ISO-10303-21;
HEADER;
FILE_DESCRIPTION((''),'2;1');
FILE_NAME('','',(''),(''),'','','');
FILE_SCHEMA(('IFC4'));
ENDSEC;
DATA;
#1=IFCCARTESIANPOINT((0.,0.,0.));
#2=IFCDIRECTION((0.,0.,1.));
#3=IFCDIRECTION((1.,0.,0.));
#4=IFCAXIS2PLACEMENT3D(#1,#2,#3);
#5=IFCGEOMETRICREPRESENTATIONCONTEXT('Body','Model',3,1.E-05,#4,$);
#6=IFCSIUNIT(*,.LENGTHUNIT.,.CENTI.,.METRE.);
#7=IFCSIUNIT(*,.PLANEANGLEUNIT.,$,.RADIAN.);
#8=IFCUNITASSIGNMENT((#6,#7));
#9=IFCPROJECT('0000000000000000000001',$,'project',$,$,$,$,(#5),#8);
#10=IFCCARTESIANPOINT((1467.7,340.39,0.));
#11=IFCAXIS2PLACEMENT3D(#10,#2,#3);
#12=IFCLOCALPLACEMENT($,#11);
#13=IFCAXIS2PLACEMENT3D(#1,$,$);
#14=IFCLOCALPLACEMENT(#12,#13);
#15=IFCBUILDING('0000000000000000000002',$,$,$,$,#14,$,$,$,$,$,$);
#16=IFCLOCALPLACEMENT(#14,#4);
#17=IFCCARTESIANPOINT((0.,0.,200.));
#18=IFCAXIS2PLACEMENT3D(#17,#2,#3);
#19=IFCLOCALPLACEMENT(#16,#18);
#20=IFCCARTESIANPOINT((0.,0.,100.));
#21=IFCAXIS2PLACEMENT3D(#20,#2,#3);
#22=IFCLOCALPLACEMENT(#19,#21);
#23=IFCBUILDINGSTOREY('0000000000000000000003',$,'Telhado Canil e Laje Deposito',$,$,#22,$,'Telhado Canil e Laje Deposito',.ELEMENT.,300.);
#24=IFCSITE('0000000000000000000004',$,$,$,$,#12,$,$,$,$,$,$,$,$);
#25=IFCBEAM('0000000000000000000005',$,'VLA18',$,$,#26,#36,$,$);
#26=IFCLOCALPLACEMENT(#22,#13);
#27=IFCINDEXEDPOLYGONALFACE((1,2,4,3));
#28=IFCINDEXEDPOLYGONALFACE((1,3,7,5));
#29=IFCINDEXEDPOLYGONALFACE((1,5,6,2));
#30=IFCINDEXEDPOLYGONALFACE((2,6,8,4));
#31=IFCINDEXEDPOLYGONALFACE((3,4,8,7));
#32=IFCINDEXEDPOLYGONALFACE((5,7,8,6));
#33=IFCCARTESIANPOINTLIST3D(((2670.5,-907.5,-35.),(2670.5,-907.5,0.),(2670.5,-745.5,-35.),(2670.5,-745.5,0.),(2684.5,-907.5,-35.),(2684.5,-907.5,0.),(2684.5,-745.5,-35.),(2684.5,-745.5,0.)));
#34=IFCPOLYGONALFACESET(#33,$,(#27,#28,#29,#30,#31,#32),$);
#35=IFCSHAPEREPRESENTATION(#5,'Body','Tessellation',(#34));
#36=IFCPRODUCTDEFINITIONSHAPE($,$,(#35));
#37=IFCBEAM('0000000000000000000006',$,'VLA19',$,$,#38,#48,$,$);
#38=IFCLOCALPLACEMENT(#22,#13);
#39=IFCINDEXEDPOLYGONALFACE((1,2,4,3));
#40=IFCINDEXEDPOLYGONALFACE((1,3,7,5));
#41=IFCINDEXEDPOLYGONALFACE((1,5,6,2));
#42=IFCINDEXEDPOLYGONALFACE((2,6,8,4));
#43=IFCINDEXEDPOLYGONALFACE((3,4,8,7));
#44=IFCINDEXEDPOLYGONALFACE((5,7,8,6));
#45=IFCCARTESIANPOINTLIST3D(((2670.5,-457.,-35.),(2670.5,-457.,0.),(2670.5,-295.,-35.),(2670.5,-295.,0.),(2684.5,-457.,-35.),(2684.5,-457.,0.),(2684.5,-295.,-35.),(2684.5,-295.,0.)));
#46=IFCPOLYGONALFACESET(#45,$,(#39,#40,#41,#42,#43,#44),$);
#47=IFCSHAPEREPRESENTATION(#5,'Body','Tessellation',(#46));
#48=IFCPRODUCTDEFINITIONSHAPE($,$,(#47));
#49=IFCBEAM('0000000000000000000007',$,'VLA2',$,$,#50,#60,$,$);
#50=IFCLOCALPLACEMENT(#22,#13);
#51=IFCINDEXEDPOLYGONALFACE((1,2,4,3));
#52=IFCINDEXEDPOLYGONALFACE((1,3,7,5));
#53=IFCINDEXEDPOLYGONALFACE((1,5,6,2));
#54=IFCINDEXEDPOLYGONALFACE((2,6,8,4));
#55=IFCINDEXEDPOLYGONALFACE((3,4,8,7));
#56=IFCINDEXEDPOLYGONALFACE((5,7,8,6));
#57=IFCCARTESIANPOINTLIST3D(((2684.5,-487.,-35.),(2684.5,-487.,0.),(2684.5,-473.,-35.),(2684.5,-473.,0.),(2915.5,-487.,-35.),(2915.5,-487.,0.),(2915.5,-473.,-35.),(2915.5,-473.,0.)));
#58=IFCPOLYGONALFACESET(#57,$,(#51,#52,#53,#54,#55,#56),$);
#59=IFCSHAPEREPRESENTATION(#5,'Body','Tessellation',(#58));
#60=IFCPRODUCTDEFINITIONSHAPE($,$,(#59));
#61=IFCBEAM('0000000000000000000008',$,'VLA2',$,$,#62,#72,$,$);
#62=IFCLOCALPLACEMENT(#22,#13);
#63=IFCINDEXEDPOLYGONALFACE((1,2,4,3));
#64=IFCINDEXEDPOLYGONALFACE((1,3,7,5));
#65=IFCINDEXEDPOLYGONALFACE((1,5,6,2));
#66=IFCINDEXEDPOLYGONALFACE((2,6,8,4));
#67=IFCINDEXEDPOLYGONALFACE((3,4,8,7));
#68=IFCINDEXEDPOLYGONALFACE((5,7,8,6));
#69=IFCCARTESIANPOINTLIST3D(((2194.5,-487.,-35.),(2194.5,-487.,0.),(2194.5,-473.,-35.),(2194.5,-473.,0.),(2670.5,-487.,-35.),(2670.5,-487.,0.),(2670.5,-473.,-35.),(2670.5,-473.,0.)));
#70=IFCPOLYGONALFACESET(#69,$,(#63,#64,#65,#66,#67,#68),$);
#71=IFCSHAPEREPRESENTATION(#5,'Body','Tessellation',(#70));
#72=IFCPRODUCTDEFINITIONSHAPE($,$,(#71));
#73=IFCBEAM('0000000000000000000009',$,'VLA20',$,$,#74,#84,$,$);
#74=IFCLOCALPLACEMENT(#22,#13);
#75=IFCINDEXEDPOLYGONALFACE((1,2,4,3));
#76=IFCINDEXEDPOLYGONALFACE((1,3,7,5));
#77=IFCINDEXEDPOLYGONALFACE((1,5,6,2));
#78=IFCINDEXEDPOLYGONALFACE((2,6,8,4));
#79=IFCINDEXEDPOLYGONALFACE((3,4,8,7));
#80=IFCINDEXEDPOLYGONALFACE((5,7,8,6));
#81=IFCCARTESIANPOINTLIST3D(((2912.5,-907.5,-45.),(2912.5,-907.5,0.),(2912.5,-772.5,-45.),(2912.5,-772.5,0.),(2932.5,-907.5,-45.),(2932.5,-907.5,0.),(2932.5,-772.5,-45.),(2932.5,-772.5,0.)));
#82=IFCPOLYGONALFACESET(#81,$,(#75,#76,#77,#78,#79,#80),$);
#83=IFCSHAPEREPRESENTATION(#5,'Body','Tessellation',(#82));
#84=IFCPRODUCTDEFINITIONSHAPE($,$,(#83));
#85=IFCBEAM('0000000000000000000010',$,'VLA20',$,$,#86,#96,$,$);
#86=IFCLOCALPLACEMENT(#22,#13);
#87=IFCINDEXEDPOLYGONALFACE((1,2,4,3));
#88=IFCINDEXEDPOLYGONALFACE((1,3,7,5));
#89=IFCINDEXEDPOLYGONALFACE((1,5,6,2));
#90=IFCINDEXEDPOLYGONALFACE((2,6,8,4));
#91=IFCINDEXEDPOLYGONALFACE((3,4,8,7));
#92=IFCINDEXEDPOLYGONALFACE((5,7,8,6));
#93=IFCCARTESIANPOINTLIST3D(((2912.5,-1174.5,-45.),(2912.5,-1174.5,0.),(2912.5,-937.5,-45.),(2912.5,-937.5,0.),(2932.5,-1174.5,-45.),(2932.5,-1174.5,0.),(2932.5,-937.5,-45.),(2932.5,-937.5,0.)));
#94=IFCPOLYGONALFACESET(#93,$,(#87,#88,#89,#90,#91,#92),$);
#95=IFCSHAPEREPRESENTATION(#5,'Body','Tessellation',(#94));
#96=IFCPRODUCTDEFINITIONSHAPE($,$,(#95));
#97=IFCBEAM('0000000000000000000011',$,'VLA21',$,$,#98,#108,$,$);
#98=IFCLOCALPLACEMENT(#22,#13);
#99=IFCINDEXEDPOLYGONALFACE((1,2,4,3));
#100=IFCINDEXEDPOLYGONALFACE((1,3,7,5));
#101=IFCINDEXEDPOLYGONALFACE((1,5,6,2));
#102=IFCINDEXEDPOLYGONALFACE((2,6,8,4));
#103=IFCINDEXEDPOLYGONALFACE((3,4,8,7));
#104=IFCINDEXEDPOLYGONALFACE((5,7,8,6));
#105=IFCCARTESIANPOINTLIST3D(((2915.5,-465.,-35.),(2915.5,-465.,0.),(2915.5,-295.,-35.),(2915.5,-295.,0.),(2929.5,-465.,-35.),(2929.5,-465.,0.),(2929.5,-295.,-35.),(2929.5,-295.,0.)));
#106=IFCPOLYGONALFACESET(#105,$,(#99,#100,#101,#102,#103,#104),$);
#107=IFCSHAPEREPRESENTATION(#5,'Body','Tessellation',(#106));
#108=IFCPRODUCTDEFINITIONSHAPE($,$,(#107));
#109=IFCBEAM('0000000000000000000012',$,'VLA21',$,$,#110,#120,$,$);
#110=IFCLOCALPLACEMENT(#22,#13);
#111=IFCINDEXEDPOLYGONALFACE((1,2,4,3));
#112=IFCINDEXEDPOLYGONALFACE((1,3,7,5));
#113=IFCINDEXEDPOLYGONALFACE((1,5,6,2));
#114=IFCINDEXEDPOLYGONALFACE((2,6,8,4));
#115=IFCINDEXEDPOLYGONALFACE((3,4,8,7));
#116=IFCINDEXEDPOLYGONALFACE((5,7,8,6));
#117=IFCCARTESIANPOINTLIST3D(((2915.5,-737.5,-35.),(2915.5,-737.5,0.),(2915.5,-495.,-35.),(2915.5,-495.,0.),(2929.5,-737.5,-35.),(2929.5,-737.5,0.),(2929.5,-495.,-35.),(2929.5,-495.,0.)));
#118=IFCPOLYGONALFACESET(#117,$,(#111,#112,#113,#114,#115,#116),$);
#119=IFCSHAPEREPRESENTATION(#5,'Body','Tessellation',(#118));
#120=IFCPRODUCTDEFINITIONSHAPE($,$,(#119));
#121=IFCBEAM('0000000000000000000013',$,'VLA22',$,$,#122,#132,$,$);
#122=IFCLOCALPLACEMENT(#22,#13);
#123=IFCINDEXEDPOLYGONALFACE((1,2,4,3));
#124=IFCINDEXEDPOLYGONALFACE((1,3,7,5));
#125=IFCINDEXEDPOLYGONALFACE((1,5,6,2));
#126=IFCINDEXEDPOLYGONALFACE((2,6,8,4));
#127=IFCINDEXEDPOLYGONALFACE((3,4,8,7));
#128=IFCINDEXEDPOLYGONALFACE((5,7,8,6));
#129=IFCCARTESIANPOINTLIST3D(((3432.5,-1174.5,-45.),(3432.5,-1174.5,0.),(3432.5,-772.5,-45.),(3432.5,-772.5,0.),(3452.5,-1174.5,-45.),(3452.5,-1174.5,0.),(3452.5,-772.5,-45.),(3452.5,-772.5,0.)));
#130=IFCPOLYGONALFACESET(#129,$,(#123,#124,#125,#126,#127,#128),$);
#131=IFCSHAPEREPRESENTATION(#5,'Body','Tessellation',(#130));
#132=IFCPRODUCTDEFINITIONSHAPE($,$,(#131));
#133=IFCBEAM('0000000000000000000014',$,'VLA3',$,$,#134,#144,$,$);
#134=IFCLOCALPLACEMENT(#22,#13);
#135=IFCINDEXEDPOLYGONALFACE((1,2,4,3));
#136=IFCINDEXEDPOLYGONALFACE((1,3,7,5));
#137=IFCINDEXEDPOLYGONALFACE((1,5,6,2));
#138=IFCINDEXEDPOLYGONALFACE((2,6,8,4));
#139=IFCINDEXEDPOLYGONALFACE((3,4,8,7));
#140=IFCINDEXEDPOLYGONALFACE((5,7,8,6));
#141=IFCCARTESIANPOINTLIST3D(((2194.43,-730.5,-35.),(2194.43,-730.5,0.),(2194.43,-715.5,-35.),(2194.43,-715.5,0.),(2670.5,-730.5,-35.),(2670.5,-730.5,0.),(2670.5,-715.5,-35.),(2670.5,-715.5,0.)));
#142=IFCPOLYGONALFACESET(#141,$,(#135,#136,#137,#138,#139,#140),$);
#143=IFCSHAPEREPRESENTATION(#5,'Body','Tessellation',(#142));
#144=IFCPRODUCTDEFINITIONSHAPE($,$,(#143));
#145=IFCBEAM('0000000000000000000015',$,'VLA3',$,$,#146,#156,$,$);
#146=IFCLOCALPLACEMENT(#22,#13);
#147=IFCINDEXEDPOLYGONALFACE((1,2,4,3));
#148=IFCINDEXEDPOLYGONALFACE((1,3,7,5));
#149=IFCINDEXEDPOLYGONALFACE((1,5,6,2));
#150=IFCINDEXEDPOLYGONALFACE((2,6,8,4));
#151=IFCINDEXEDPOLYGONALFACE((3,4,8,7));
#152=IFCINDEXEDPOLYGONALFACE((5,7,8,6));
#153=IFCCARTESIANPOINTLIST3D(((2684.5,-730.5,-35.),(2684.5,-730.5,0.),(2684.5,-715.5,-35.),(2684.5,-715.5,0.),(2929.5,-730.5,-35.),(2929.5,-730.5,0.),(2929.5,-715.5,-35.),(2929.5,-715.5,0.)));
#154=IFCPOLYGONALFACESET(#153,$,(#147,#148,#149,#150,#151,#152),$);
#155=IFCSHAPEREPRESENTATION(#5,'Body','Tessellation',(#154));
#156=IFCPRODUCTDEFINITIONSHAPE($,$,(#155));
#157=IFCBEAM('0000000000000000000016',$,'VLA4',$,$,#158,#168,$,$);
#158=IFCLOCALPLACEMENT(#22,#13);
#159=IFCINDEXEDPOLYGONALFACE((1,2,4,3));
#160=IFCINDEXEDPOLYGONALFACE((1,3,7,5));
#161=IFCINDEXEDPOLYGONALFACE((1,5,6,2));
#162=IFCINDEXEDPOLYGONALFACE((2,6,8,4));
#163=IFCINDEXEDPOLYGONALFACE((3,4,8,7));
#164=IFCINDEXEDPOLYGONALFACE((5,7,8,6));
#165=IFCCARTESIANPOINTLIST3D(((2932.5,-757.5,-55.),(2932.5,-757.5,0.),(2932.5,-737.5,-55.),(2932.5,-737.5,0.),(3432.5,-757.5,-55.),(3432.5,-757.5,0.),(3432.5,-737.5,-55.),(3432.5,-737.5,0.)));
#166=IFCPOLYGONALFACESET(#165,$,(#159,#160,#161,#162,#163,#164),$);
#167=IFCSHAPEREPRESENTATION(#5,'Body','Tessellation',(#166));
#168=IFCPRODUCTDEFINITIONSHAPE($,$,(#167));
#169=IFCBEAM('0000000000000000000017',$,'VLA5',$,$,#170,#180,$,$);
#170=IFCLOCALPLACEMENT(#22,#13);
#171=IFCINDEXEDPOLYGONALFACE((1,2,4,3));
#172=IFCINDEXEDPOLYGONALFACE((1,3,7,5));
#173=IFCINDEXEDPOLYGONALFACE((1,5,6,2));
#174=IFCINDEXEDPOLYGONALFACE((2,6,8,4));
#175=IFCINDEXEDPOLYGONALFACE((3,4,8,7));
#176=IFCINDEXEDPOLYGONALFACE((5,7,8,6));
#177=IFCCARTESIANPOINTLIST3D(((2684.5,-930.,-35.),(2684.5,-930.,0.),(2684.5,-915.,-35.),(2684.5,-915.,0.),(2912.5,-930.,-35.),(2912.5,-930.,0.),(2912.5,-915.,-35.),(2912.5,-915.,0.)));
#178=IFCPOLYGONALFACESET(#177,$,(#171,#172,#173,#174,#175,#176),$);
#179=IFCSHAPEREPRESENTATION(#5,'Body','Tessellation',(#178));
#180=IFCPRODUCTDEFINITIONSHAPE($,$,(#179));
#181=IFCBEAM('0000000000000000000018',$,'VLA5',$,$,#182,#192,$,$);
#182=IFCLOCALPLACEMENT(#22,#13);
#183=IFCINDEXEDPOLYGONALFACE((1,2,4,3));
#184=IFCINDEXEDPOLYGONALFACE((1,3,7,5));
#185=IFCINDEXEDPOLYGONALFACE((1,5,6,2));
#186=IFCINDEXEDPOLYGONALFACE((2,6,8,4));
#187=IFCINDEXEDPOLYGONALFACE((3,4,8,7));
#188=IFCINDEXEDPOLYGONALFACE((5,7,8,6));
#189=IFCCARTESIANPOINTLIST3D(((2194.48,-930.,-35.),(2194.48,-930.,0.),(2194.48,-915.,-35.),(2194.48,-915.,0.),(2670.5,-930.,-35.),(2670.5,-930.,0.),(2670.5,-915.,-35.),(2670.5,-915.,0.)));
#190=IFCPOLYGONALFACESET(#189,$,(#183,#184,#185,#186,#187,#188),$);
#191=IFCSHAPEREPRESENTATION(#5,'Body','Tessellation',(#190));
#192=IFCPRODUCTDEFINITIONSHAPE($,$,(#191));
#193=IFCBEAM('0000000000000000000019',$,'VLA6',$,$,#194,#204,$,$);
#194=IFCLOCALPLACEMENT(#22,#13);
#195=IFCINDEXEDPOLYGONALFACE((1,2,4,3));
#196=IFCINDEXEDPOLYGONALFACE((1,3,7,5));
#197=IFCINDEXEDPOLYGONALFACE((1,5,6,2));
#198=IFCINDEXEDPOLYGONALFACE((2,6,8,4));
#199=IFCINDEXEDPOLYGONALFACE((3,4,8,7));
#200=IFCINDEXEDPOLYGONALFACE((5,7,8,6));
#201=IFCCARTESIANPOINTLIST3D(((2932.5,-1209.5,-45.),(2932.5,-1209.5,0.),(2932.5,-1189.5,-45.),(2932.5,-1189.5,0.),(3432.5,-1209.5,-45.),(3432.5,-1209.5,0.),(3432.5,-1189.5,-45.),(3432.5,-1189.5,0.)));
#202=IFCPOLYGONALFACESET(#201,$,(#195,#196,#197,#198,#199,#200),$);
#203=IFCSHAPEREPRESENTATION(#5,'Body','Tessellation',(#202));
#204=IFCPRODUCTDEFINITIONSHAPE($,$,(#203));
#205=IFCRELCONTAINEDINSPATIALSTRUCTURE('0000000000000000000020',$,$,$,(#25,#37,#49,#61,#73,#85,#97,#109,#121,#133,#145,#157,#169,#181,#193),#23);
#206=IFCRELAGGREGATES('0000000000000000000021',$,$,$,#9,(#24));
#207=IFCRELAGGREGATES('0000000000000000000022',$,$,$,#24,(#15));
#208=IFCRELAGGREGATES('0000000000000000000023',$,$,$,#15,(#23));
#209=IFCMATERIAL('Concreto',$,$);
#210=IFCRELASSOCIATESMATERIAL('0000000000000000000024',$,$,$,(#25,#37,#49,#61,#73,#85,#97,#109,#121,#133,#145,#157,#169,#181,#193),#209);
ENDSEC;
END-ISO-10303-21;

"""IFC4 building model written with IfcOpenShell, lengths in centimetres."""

from ifc_helpers import new_model, si_unit, frame, origin, origin_with_axes, origin_2d_with_axis, place, context, project, spatial, rectangle, extrude, material, element, save


model = new_model("IFC4")

# Units and contexts
model_context = context("Model", 3, precision=1e-05, world=origin_with_axes(), identifier="Body")
ifc_project = project(units=[si_unit("LENGTHUNIT", "METRE", prefix="CENTI"), si_unit("PLANEANGLEUNIT", "RADIAN")], contexts=[model_context])

# Site, building, storey
site_placement = place(None, frame((1467.7, 340.39, 0.0), z_axis=(0.0, 0.0, 1.0), x_axis=(1.0, 0.0, 0.0)))
site = spatial("IfcSite", under=ifc_project, at=site_placement)
building_placement = place(site_placement, origin())
building = spatial("IfcBuilding", under=site, at=building_placement)
placement_1 = place(building_placement, origin_with_axes())
placement_2 = place(placement_1, frame((0.0, 0.0, 200.0), z_axis=(0.0, 0.0, 1.0), x_axis=(1.0, 0.0, 0.0)))
storey_placement = place(placement_2, frame((0.0, 0.0, 100.0), z_axis=(0.0, 0.0, 1.0), x_axis=(1.0, 0.0, 0.0)))
storey = spatial("IfcBuildingStorey", under=building, at=storey_placement, Name="Telhado Canil e Laje Deposito", LongName="Telhado Canil e Laje Deposito", CompositionType="ELEMENT", Elevation=300.0)

# Shared definitions
ifc_material = material(Name="Concreto")

# Beams
for number, where, z_axis, x_axis, name in (
    (1, (2677.5, -826.5, 0.0), (0.0, 0.0, 1.0), (1.0, 0.0, 0.0), "VLA18"),
    (2, (2677.5, -376.0, 0.0), (0.0, 0.0, 1.0), (1.0, 0.0, 0.0), "VLA19"),
):
    element("IfcBeam", number, at=place(storey_placement, frame(where, z_axis=z_axis, x_axis=x_axis)), inside=storey, material=ifc_material, Name=name, context=model_context, shape_type="SolidModel", body=[
        extrude(rectangle(XDim=14.0, YDim=35.0, at=origin_2d_with_axis()), frame((0.0, -81.0, -17.5), z_axis=(0.0, 1.0, 0.0), x_axis=(1.0, 0.0, 0.0)), (0.0, 0.0, 1.0), 162.0),
    ])
beam_1_placement = place(storey_placement, frame((2800.0, -480.0, 0.0), z_axis=(0.0, 0.0, 1.0), x_axis=(1.0, 0.0, 0.0)))
element("IfcBeam", 3, at=beam_1_placement, inside=storey, material=ifc_material, Name="VLA2", context=model_context, shape_type="SolidModel", body=[
    extrude(rectangle(XDim=14.0, YDim=35.0, at=origin_2d_with_axis()), frame((-115.5, 0.0, -17.5), z_axis=(1.0, 0.0, 0.0), x_axis=(0.0, 1.0, 0.0)), (0.0, 0.0, 1.0), 231.0),
])
beam_2_placement = place(storey_placement, frame((2432.5, -480.0, 0.0), z_axis=(0.0, 0.0, 1.0), x_axis=(1.0, 0.0, 0.0)))
element("IfcBeam", 4, at=beam_2_placement, inside=storey, material=ifc_material, Name="VLA2", context=model_context, shape_type="SolidModel", body=[
    extrude(rectangle(XDim=14.0, YDim=35.0, at=origin_2d_with_axis()), frame((-238.0, 0.0, -17.5), z_axis=(1.0, 0.0, 0.0), x_axis=(0.0, 1.0, 0.0)), (0.0, 0.0, 1.0), 476.0),
])
beam_3_placement = place(storey_placement, frame((2922.5, -840.0, 0.0), z_axis=(0.0, 0.0, 1.0), x_axis=(1.0, 0.0, 0.0)))
element("IfcBeam", 5, at=beam_3_placement, inside=storey, material=ifc_material, Name="VLA20", context=model_context, shape_type="SolidModel", body=[
    extrude(rectangle(XDim=20.0, YDim=45.0, at=origin_2d_with_axis()), frame((0.0, -67.5, -22.5), z_axis=(0.0, 1.0, 0.0), x_axis=(1.0, 0.0, 0.0)), (0.0, 0.0, 1.0), 135.0),
])
beam_4_placement = place(storey_placement, frame((2922.5, -1056.0, 0.0), z_axis=(0.0, 0.0, 1.0), x_axis=(1.0, 0.0, 0.0)))
element("IfcBeam", 6, at=beam_4_placement, inside=storey, material=ifc_material, Name="VLA20", context=model_context, shape_type="SolidModel", body=[
    extrude(rectangle(XDim=20.0, YDim=45.0, at=origin_2d_with_axis()), frame((0.0, -118.5, -22.5), z_axis=(0.0, 1.0, 0.0), x_axis=(1.0, 0.0, 0.0)), (0.0, 0.0, 1.0), 237.0),
])
beam_5_placement = place(storey_placement, frame((2922.5, -380.0, 0.0), z_axis=(0.0, 0.0, 1.0), x_axis=(1.0, 0.0, 0.0)))
element("IfcBeam", 7, at=beam_5_placement, inside=storey, material=ifc_material, Name="VLA21", context=model_context, shape_type="SolidModel", body=[
    extrude(rectangle(XDim=14.0, YDim=35.0, at=origin_2d_with_axis()), frame((0.0, -85.0, -17.5), z_axis=(0.0, 1.0, 0.0), x_axis=(1.0, 0.0, 0.0)), (0.0, 0.0, 1.0), 170.0),
])
beam_6_placement = place(storey_placement, frame((2922.5, -616.25, 0.0), z_axis=(0.0, 0.0, 1.0), x_axis=(1.0, 0.0, 0.0)))
element("IfcBeam", 8, at=beam_6_placement, inside=storey, material=ifc_material, Name="VLA21", context=model_context, shape_type="SolidModel", body=[
    extrude(rectangle(XDim=14.0, YDim=35.0, at=origin_2d_with_axis()), frame((0.0, -121.25, -17.5), z_axis=(0.0, 1.0, 0.0), x_axis=(1.0, 0.0, 0.0)), (0.0, 0.0, 1.0), 242.5),
])
beam_7_placement = place(storey_placement, frame((3442.5, -973.5, 0.0), z_axis=(0.0, 0.0, 1.0), x_axis=(1.0, 0.0, 0.0)))
element("IfcBeam", 9, at=beam_7_placement, inside=storey, material=ifc_material, Name="VLA22", context=model_context, shape_type="SolidModel", body=[
    extrude(rectangle(XDim=20.0, YDim=45.0, at=origin_2d_with_axis()), frame((0.0, -201.0, -22.5), z_axis=(0.0, 1.0, 0.0), x_axis=(1.0, 0.0, 0.0)), (0.0, 0.0, 1.0), 402.0),
])
beam_8_placement = place(storey_placement, frame((2432.47, -723.0, 0.0), z_axis=(0.0, 0.0, 1.0), x_axis=(1.0, 0.0, 0.0)))
element("IfcBeam", 10, at=beam_8_placement, inside=storey, material=ifc_material, Name="VLA3", context=model_context, shape_type="SolidModel", body=[
    extrude(rectangle(XDim=15.0, YDim=35.0, at=origin_2d_with_axis()), frame((-238.03, 0.0, -17.5), z_axis=(1.0, 0.0, 0.0), x_axis=(0.0, 1.0, 0.0)), (0.0, 0.0, 1.0), 476.07),
])
beam_9_placement = place(storey_placement, frame((2807.0, -723.0, 0.0), z_axis=(0.0, 0.0, 1.0), x_axis=(1.0, 0.0, 0.0)))
element("IfcBeam", 11, at=beam_9_placement, inside=storey, material=ifc_material, Name="VLA3", context=model_context, shape_type="SolidModel", body=[
    extrude(rectangle(XDim=15.0, YDim=35.0, at=origin_2d_with_axis()), frame((-122.5, 0.0, -17.5), z_axis=(1.0, 0.0, 0.0), x_axis=(0.0, 1.0, 0.0)), (0.0, 0.0, 1.0), 245.0),
])
beam_10_placement = place(storey_placement, frame((3182.5, -747.5, 0.0), z_axis=(0.0, 0.0, 1.0), x_axis=(1.0, 0.0, 0.0)))
element("IfcBeam", 12, at=beam_10_placement, inside=storey, material=ifc_material, Name="VLA4", context=model_context, shape_type="SolidModel", body=[
    extrude(rectangle(XDim=20.0, YDim=55.0, at=origin_2d_with_axis()), frame((-250.0, 0.0, -27.5), z_axis=(1.0, 0.0, 0.0), x_axis=(0.0, 1.0, 0.0)), (0.0, 0.0, 1.0), 500.0),
])
beam_11_placement = place(storey_placement, frame((2798.5, -922.5, 0.0), z_axis=(0.0, 0.0, 1.0), x_axis=(1.0, 0.0, 0.0)))
element("IfcBeam", 13, at=beam_11_placement, inside=storey, material=ifc_material, Name="VLA5", context=model_context, shape_type="SolidModel", body=[
    extrude(rectangle(XDim=15.0, YDim=35.0, at=origin_2d_with_axis()), frame((-114.0, 0.0, -17.5), z_axis=(1.0, 0.0, 0.0), x_axis=(0.0, 1.0, 0.0)), (0.0, 0.0, 1.0), 228.0),
])
beam_12_placement = place(storey_placement, frame((2432.49, -922.5, 0.0), z_axis=(0.0, 0.0, 1.0), x_axis=(1.0, 0.0, 0.0)))
element("IfcBeam", 14, at=beam_12_placement, inside=storey, material=ifc_material, Name="VLA5", context=model_context, shape_type="SolidModel", body=[
    extrude(rectangle(XDim=15.0, YDim=35.0, at=origin_2d_with_axis()), frame((-238.01, 0.0, -17.5), z_axis=(1.0, 0.0, 0.0), x_axis=(0.0, 1.0, 0.0)), (0.0, 0.0, 1.0), 476.02),
])
beam_13_placement = place(storey_placement, frame((3182.5, -1199.5, 0.0), z_axis=(0.0, 0.0, 1.0), x_axis=(1.0, 0.0, 0.0)))
element("IfcBeam", 15, at=beam_13_placement, inside=storey, material=ifc_material, Name="VLA6", context=model_context, shape_type="SolidModel", body=[
    extrude(rectangle(XDim=20.0, YDim=45.0, at=origin_2d_with_axis()), frame((-250.0, 0.0, -22.5), z_axis=(1.0, 0.0, 0.0), x_axis=(0.0, 1.0, 0.0)), (0.0, 0.0, 1.0), 500.0),
])

save(model, "model.ifc")
